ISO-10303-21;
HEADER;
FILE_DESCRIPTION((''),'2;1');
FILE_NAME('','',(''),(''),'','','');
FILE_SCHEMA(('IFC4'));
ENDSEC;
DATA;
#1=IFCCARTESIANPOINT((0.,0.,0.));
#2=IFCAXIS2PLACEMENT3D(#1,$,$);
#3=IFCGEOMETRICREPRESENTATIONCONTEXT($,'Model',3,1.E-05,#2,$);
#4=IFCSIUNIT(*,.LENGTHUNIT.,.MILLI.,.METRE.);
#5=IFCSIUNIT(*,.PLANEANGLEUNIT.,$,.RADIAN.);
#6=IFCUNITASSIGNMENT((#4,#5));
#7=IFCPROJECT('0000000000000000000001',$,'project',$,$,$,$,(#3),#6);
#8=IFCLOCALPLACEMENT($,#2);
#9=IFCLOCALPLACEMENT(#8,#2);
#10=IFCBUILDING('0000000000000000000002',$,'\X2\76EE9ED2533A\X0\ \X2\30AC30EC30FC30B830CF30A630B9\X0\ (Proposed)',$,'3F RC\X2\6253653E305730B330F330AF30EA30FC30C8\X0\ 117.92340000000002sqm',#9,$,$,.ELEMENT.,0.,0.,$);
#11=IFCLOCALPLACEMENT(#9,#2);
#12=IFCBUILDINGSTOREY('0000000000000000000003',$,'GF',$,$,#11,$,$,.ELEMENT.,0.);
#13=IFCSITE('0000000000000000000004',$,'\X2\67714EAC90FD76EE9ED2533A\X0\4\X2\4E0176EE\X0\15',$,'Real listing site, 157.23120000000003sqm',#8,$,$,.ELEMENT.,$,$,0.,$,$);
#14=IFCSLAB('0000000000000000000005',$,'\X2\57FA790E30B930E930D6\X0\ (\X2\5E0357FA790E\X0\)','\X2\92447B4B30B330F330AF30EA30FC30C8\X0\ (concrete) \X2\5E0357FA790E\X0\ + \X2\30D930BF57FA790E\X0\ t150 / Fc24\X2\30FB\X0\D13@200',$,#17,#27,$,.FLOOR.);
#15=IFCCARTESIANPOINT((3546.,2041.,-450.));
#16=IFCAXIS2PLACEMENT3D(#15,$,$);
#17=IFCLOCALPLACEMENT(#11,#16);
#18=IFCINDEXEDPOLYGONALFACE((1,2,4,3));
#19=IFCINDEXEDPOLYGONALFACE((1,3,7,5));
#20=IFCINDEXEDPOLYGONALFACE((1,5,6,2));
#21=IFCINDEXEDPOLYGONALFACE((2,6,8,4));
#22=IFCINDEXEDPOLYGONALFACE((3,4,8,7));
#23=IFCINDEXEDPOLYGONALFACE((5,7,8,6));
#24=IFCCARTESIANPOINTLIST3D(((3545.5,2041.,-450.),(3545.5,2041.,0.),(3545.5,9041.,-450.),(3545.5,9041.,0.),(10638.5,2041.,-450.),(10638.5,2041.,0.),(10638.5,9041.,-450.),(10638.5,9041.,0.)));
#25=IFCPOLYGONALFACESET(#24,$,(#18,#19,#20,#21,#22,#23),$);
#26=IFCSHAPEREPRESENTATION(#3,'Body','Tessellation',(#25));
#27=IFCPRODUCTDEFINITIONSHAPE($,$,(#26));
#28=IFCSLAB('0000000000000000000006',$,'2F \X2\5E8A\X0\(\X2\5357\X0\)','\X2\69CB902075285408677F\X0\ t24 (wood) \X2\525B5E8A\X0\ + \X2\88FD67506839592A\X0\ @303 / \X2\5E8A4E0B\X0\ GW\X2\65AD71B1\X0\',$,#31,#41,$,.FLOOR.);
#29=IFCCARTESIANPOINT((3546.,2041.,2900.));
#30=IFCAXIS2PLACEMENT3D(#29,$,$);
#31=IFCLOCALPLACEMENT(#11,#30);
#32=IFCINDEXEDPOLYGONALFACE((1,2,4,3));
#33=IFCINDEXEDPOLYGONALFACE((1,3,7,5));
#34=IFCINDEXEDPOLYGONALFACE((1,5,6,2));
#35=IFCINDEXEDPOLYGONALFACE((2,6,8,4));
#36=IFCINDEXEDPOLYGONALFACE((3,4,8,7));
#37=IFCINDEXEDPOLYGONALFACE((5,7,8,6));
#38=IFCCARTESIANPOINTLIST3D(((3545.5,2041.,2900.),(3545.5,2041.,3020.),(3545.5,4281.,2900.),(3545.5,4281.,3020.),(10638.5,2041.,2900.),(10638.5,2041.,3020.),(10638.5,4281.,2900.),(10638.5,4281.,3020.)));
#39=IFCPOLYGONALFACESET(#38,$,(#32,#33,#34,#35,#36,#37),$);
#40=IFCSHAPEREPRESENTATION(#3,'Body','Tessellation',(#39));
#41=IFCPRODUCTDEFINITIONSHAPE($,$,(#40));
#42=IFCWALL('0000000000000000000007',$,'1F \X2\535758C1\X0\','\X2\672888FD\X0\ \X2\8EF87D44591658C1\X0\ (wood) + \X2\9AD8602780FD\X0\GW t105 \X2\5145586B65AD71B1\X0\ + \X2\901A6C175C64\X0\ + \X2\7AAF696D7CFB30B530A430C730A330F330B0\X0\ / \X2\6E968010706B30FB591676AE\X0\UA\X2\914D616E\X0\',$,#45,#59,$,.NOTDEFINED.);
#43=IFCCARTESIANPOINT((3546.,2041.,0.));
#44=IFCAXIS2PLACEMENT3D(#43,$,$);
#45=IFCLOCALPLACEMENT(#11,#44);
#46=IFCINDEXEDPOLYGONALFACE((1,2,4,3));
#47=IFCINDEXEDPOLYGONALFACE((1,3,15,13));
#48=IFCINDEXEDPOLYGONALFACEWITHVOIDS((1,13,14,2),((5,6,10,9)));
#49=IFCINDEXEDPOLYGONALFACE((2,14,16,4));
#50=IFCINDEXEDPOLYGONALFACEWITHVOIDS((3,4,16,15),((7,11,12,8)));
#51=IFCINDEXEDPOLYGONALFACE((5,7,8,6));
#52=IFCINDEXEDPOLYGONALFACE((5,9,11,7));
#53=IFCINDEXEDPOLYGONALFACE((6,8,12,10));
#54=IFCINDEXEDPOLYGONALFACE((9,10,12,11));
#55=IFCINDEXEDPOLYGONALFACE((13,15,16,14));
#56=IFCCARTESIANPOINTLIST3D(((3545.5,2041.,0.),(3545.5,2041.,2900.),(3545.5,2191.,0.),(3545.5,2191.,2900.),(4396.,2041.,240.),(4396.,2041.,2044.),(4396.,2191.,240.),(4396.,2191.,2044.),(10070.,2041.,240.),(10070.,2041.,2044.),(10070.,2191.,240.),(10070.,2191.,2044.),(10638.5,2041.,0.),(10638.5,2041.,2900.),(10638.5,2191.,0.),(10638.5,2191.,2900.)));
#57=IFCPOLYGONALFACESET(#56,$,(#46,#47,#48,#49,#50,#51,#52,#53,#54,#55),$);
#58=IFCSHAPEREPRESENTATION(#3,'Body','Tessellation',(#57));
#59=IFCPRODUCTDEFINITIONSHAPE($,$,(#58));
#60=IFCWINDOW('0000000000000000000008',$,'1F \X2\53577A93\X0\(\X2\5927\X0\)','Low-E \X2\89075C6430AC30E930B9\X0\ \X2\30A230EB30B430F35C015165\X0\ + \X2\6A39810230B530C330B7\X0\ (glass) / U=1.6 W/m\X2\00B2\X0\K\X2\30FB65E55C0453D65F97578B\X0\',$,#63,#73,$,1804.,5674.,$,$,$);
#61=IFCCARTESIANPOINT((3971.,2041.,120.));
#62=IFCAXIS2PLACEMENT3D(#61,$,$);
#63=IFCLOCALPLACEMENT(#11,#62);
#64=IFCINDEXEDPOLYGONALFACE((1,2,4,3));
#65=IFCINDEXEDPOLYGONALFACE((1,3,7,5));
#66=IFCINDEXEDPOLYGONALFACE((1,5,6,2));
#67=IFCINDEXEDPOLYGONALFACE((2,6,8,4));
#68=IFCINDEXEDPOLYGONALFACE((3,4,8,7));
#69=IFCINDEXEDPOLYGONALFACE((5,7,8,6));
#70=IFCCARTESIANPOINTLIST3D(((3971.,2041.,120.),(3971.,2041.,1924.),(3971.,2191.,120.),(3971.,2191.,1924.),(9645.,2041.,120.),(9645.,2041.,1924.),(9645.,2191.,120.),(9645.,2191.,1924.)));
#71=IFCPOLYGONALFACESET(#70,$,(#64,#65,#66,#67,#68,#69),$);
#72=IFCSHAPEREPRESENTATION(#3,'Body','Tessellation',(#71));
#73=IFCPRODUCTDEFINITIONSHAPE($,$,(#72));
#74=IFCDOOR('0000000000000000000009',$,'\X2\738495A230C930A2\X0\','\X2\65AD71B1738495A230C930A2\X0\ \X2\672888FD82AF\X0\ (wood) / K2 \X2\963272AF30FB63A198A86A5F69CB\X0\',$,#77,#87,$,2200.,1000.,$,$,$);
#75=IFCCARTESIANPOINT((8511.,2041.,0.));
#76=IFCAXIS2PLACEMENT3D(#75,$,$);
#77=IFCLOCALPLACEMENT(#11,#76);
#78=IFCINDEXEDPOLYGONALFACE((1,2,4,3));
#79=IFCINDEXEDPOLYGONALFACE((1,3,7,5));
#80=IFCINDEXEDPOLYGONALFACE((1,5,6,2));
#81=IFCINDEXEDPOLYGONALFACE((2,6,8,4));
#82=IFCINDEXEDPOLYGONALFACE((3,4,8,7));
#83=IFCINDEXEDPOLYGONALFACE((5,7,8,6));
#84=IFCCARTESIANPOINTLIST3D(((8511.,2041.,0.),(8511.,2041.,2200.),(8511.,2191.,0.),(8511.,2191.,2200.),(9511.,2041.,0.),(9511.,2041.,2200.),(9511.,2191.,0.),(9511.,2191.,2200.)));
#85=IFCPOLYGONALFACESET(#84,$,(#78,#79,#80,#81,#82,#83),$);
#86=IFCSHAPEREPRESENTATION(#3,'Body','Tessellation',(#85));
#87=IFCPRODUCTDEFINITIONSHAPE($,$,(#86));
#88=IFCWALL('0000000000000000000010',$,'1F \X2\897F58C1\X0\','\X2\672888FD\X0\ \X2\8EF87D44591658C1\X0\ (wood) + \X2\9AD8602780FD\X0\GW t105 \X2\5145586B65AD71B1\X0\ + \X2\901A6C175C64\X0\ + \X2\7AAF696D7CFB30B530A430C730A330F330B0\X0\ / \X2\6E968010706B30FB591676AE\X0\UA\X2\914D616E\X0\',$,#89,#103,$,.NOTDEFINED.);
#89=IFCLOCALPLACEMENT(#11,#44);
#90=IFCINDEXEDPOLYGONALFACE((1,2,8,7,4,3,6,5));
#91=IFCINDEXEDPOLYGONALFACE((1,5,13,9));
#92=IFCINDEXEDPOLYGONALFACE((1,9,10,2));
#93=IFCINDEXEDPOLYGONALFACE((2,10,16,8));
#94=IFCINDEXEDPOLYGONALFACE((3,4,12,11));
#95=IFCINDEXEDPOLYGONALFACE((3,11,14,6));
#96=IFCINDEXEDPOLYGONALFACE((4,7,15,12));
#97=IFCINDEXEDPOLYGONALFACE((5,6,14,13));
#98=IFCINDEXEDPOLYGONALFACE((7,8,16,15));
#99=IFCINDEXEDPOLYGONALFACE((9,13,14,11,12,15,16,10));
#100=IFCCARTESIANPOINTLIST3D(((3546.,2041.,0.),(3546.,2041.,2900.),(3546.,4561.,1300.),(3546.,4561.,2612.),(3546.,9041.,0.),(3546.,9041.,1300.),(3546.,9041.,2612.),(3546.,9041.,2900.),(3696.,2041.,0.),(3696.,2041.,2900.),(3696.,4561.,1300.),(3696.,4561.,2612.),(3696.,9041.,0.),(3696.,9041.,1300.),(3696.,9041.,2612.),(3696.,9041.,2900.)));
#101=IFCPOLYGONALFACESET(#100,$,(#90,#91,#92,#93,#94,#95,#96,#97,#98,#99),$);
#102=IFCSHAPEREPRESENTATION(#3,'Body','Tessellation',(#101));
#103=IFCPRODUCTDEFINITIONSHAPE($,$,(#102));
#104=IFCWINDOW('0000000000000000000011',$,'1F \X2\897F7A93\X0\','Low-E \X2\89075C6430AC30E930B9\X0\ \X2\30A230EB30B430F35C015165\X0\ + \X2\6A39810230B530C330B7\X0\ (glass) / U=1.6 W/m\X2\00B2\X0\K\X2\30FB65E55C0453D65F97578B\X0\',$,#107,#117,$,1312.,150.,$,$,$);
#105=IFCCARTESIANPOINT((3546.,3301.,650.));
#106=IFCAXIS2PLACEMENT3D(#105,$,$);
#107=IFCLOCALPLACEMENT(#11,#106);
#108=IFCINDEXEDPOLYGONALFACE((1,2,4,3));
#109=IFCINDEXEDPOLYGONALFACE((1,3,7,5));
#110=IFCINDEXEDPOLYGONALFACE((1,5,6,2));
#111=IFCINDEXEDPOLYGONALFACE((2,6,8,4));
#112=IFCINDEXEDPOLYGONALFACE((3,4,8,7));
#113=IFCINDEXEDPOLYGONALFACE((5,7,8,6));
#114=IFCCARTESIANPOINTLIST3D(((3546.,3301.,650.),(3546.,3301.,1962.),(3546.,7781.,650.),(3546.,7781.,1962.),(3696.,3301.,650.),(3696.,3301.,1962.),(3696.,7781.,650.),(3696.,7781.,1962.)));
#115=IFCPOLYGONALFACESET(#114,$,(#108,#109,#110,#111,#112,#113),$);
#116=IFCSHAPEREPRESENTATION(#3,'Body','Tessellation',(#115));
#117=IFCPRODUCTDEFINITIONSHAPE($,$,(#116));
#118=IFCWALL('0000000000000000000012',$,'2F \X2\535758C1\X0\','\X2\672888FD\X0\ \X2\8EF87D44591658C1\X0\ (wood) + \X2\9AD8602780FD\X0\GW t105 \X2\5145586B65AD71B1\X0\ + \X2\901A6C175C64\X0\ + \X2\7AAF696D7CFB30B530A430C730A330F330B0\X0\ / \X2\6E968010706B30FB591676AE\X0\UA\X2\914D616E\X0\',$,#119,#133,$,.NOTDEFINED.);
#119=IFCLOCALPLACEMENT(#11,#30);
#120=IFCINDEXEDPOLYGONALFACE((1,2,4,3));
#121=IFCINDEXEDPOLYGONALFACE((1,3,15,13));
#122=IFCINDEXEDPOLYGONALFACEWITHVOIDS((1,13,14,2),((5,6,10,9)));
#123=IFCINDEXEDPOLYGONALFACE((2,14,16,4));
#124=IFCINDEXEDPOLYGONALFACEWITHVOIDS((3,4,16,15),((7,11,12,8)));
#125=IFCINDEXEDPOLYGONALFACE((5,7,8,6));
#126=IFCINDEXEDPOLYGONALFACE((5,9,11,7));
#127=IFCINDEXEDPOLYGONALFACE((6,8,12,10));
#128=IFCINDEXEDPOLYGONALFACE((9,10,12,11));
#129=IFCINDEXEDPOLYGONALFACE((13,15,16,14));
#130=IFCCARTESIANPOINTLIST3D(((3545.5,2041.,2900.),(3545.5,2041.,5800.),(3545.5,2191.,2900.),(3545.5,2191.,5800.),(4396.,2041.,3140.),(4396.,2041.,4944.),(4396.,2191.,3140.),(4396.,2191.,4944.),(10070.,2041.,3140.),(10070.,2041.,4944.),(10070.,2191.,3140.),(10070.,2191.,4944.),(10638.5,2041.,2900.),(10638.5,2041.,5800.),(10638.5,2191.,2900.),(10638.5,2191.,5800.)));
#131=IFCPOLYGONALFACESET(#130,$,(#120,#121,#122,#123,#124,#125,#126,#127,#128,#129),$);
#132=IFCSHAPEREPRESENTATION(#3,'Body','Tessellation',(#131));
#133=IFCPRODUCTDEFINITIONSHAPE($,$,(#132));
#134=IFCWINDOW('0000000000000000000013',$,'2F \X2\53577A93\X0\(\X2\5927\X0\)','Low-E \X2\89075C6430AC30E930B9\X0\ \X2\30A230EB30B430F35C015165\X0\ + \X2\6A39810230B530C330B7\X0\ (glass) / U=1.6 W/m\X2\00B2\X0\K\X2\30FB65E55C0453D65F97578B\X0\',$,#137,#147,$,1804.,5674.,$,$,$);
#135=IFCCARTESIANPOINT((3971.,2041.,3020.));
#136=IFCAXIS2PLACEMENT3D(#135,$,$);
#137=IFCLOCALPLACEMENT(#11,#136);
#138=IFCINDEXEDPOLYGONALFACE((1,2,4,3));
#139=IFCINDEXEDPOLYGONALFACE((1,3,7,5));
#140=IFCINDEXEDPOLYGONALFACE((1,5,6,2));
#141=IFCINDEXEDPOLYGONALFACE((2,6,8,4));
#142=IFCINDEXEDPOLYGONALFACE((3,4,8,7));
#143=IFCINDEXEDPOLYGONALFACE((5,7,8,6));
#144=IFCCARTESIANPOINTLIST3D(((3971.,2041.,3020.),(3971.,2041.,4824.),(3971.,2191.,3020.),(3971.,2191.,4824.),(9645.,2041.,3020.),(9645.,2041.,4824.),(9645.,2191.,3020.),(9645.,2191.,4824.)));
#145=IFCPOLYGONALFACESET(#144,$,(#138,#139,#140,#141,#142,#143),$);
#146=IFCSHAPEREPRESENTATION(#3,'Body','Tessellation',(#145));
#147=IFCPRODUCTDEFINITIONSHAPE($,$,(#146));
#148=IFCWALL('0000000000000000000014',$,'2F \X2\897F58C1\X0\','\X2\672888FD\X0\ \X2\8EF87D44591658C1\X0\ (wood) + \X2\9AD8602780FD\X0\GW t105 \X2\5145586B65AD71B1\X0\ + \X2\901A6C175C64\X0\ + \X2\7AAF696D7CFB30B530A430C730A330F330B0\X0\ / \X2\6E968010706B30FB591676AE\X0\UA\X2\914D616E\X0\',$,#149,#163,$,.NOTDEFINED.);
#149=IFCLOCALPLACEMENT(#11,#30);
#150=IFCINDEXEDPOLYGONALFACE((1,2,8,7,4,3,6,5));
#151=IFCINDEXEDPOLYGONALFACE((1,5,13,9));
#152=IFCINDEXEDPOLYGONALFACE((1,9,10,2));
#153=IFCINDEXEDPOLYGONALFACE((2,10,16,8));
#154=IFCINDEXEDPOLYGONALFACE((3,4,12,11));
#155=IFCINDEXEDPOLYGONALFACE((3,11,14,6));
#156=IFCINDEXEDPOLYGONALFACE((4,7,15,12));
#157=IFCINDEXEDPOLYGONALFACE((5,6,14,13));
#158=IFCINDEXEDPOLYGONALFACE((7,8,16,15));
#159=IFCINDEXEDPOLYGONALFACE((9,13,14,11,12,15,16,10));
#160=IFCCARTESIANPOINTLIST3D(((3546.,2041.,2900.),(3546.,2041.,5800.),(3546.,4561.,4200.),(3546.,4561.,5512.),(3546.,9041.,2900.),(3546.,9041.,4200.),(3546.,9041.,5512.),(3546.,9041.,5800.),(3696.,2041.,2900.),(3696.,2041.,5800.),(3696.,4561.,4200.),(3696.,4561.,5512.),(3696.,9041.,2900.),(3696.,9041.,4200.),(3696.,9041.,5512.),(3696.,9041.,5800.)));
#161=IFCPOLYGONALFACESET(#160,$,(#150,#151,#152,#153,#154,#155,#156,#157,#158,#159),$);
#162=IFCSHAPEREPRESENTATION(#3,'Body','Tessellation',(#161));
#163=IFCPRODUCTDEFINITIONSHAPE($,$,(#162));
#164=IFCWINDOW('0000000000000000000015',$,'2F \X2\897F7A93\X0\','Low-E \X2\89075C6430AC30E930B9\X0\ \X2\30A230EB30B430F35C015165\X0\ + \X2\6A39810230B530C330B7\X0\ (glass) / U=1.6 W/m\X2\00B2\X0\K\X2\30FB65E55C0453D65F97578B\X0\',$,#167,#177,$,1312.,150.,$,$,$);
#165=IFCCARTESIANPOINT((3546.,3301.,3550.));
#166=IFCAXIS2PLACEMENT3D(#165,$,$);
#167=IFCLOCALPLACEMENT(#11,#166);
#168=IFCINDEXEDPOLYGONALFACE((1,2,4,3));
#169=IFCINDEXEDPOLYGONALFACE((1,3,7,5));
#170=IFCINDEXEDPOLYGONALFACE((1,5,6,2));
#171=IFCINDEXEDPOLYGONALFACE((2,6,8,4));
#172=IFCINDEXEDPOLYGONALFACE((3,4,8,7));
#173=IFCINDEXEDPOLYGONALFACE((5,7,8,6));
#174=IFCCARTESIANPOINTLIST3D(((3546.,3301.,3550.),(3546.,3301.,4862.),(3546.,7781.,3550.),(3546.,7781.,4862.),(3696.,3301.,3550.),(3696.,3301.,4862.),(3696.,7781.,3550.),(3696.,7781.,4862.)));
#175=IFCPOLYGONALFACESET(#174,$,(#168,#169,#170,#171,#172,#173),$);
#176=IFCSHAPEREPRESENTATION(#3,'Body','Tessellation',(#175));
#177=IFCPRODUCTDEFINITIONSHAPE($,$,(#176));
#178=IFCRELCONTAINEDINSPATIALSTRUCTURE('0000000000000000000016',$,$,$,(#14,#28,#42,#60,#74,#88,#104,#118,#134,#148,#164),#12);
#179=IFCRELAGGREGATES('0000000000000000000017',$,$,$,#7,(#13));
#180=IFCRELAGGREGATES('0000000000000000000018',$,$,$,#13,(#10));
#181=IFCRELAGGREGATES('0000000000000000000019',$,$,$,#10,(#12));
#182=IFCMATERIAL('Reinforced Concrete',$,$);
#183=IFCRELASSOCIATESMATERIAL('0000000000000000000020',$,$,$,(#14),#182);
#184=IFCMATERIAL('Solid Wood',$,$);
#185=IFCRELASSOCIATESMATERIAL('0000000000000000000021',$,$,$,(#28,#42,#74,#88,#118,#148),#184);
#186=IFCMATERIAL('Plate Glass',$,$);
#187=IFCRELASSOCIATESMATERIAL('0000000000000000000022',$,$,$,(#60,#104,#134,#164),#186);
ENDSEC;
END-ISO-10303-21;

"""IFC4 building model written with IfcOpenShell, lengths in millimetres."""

from ifc_helpers import new_model, si_unit, frame, frame_2d, origin, place, context, project, spatial, rectangle, extrude, material, element, fill, save


model = new_model("IFC4")

# Units and contexts
model_context = context("Model", 3, precision=1e-05, world=origin())
ifc_project = project(units=[si_unit("LENGTHUNIT", "METRE", prefix="MILLI"), si_unit("PLANEANGLEUNIT", "RADIAN")], contexts=[model_context])

# Site, building, storey
site_placement = place(None, origin())
site = spatial("IfcSite", under=ifc_project, at=site_placement, Name="東京都目黒区4丁目15", ObjectType="Real listing site, 157.23120000000003sqm", CompositionType="ELEMENT", RefElevation=0.0)
building_placement = place(site_placement, origin())
building = spatial("IfcBuilding", under=site, at=building_placement, Name="目黒区 ガレージハウス (Proposed)", ObjectType="3F RC打放しコンクリート 117.92340000000002sqm", CompositionType="ELEMENT", ElevationOfRefHeight=0.0, ElevationOfTerrain=0.0)
storey_placement = place(building_placement, origin())
storey = spatial("IfcBuildingStorey", under=building, at=storey_placement, Name="GF", CompositionType="ELEMENT", Elevation=0.0)

# Slabs
ifc_material_1 = material(Name="Reinforced Concrete")
slab_1_placement = place(storey_placement, frame((3546.0, 2041.0, -450.0)))
element("IfcSlab", 1, at=slab_1_placement, inside=storey, material=ifc_material_1, Name="基礎スラブ (布基礎)", Description="鉄筋コンクリート (concrete) 布基礎 + ベタ基礎 t150 / Fc24・D13@200", PredefinedType="FLOOR", context=model_context, shape_type="SweptSolid", body=[
    extrude(rectangle(XDim=7093.0, YDim=7000.0, at=frame_2d((3546.0, 3500.0))), frame((3546.0, 2041.0, -450.0)), (0.0, 0.0, 1.0), 450.0),
])
ifc_material_2 = material(Name="Solid Wood")
slab_2_placement = place(storey_placement, frame((3546.0, 2041.0, 2900.0)))
element("IfcSlab", 2, at=slab_2_placement, inside=storey, material=ifc_material_2, Name="2F 床(南)", Description="構造用合板 t24 (wood) 剛床 + 製材根太 @303 / 床下 GW断熱", PredefinedType="FLOOR", context=model_context, shape_type="SweptSolid", body=[
    extrude(rectangle(XDim=7093.0, YDim=2240.0, at=frame_2d((3546.0, 1120.0))), frame((3546.0, 2041.0, 2900.0)), (0.0, 0.0, 1.0), 120.0),
])

# Wall, openings, window, door
wall_1_placement = place(storey_placement, frame((3546.0, 2041.0, 0.0)))
wall_1 = element("IfcWall", 3, at=wall_1_placement, inside=storey, material=ifc_material_2, Name="1F 南壁", Description="木製 軸組外壁 (wood) + 高性能GW t105 充填断熱 + 通気層 + 窯業系サイディング / 準耐火・外皮UA配慮", PredefinedType="NOTDEFINED", context=model_context, shape_type="SweptSolid", body=[
    extrude(rectangle(XDim=7093.0, YDim=150.0, at=frame_2d((3546.0, 75.0))), frame((3546.0, 2041.0, 0.0)), (0.0, 0.0, 1.0), 2900.0),
])
opening_1_placement = place(storey_placement, frame((3971.0, 2041.0, 120.0)))
opening_1 = element("IfcOpeningElement", 4, at=opening_1_placement, cuts=wall_1, PredefinedType="NOTDEFINED", context=model_context, shape_type="SweptSolid", body=[
    extrude(rectangle(XDim=5674.0, YDim=150.0, at=frame_2d((2837.0, 75.0))), frame((3971.0, 2041.0, 120.0)), (0.0, 0.0, 1.0), 1804.0),
])
opening_2_placement = place(storey_placement, frame((8511.0, 2041.0, 0.0)))
opening_2 = element("IfcOpeningElement", 5, at=opening_2_placement, cuts=wall_1, PredefinedType="NOTDEFINED", context=model_context, shape_type="SweptSolid", body=[
    extrude(rectangle(XDim=1000.0, YDim=150.0, at=frame_2d((500.0, 75.0))), frame((8511.0, 2041.0, 0.0)), (0.0, 0.0, 1.0), 2200.0),
])
ifc_material_3 = material(Name="Plate Glass")
window_1_placement = place(storey_placement, frame((3971.0, 2041.0, 120.0)))
window_1 = element("IfcWindow", 6, at=window_1_placement, inside=storey, material=ifc_material_3, Name="1F 南窓(大)", Description="Low-E 複層ガラス アルゴン封入 + 樹脂サッシ (glass) / U=1.6 W/m²K・日射取得型", OverallHeight=1804.0, OverallWidth=5674.0, context=model_context, shape_type="SweptSolid", body=[
    extrude(rectangle(XDim=5674.0, YDim=150.0, at=frame_2d((2837.0, 75.0))), frame((3971.0, 2041.0, 120.0)), (0.0, 0.0, 1.0), 1804.0),
])
fill(opening_1, window_1)
door_placement = place(storey_placement, frame((8511.0, 2041.0, 0.0)))
door = element("IfcDoor", 7, at=door_placement, inside=storey, material=ifc_material_2, Name="玄関ドア", Description="断熱玄関ドア 木製芯 (wood) / K2 防犯・採風機構", OverallHeight=2200.0, OverallWidth=1000.0, context=model_context, shape_type="SweptSolid", body=[
    extrude(rectangle(XDim=1000.0, YDim=150.0, at=frame_2d((500.0, 75.0))), frame((8511.0, 2041.0, 0.0)), (0.0, 0.0, 1.0), 2200.0),
])
fill(opening_2, door)

# Walls, openings, windows
wall_2_placement = place(storey_placement, frame((3546.0, 2041.0, 0.0)))
wall_2 = element("IfcWall", 8, at=wall_2_placement, inside=storey, material=ifc_material_2, Name="1F 西壁", Description="木製 軸組外壁 (wood) + 高性能GW t105 充填断熱 + 通気層 + 窯業系サイディング / 準耐火・外皮UA配慮", PredefinedType="NOTDEFINED", context=model_context, shape_type="SweptSolid", body=[
    extrude(rectangle(XDim=150.0, YDim=7000.0, at=frame_2d((75.0, 3500.0))), frame((3546.0, 2041.0, 0.0)), (0.0, 0.0, 1.0), 2900.0),
])
opening_3_placement = place(storey_placement, frame((3546.0, 3301.0, 650.0)))
opening_3 = element("IfcOpeningElement", 9, at=opening_3_placement, cuts=wall_2, PredefinedType="NOTDEFINED", context=model_context, shape_type="SweptSolid", body=[
    extrude(rectangle(XDim=150.0, YDim=4480.0, at=frame_2d((75.0, 2240.0))), frame((3546.0, 3301.0, 650.0)), (0.0, 0.0, 1.0), 1312.0),
])
window_2_placement = place(storey_placement, frame((3546.0, 3301.0, 650.0)))
window_2 = element("IfcWindow", 10, at=window_2_placement, inside=storey, material=ifc_material_3, Name="1F 西窓", Description="Low-E 複層ガラス アルゴン封入 + 樹脂サッシ (glass) / U=1.6 W/m²K・日射取得型", OverallHeight=1312.0, OverallWidth=150.0, context=model_context, shape_type="SweptSolid", body=[
    extrude(rectangle(XDim=150.0, YDim=4480.0, at=frame_2d((75.0, 2240.0))), frame((3546.0, 3301.0, 650.0)), (0.0, 0.0, 1.0), 1312.0),
])
fill(opening_3, window_2)
wall_3_placement = place(storey_placement, frame((3546.0, 2041.0, 2900.0)))
wall_3 = element("IfcWall", 11, at=wall_3_placement, inside=storey, material=ifc_material_2, Name="2F 南壁", Description="木製 軸組外壁 (wood) + 高性能GW t105 充填断熱 + 通気層 + 窯業系サイディング / 準耐火・外皮UA配慮", PredefinedType="NOTDEFINED", context=model_context, shape_type="SweptSolid", body=[
    extrude(rectangle(XDim=7093.0, YDim=150.0, at=frame_2d((3546.0, 75.0))), frame((3546.0, 2041.0, 2900.0)), (0.0, 0.0, 1.0), 2900.0),
])
opening_4_placement = place(storey_placement, frame((3971.0, 2041.0, 3020.0)))
opening_4 = element("IfcOpeningElement", 12, at=opening_4_placement, cuts=wall_3, PredefinedType="NOTDEFINED", context=model_context, shape_type="SweptSolid", body=[
    extrude(rectangle(XDim=5674.0, YDim=150.0, at=frame_2d((2837.0, 75.0))), frame((3971.0, 2041.0, 3020.0)), (0.0, 0.0, 1.0), 1804.0),
])
window_3_placement = place(storey_placement, frame((3971.0, 2041.0, 3020.0)))
window_3 = element("IfcWindow", 13, at=window_3_placement, inside=storey, material=ifc_material_3, Name="2F 南窓(大)", Description="Low-E 複層ガラス アルゴン封入 + 樹脂サッシ (glass) / U=1.6 W/m²K・日射取得型", OverallHeight=1804.0, OverallWidth=5674.0, context=model_context, shape_type="SweptSolid", body=[
    extrude(rectangle(XDim=5674.0, YDim=150.0, at=frame_2d((2837.0, 75.0))), frame((3971.0, 2041.0, 3020.0)), (0.0, 0.0, 1.0), 1804.0),
])
fill(opening_4, window_3)
wall_4_placement = place(storey_placement, frame((3546.0, 2041.0, 2900.0)))
wall_4 = element("IfcWall", 14, at=wall_4_placement, inside=storey, material=ifc_material_2, Name="2F 西壁", Description="木製 軸組外壁 (wood) + 高性能GW t105 充填断熱 + 通気層 + 窯業系サイディング / 準耐火・外皮UA配慮", PredefinedType="NOTDEFINED", context=model_context, shape_type="SweptSolid", body=[
    extrude(rectangle(XDim=150.0, YDim=7000.0, at=frame_2d((75.0, 3500.0))), frame((3546.0, 2041.0, 2900.0)), (0.0, 0.0, 1.0), 2900.0),
])
opening_5_placement = place(storey_placement, frame((3546.0, 3301.0, 3550.0)))
opening_5 = element("IfcOpeningElement", 15, at=opening_5_placement, cuts=wall_4, PredefinedType="NOTDEFINED", context=model_context, shape_type="SweptSolid", body=[
    extrude(rectangle(XDim=150.0, YDim=4480.0, at=frame_2d((75.0, 2240.0))), frame((3546.0, 3301.0, 3550.0)), (0.0, 0.0, 1.0), 1312.0),
])
window_4_placement = place(storey_placement, frame((3546.0, 3301.0, 3550.0)))
window_4 = element("IfcWindow", 16, at=window_4_placement, inside=storey, material=ifc_material_3, Name="2F 西窓", Description="Low-E 複層ガラス アルゴン封入 + 樹脂サッシ (glass) / U=1.6 W/m²K・日射取得型", OverallHeight=1312.0, OverallWidth=150.0, context=model_context, shape_type="SweptSolid", body=[
    extrude(rectangle(XDim=150.0, YDim=4480.0, at=frame_2d((75.0, 2240.0))), frame((3546.0, 3301.0, 3550.0)), (0.0, 0.0, 1.0), 1312.0),
])
fill(opening_5, window_4)

save(model, "model.ifc")
